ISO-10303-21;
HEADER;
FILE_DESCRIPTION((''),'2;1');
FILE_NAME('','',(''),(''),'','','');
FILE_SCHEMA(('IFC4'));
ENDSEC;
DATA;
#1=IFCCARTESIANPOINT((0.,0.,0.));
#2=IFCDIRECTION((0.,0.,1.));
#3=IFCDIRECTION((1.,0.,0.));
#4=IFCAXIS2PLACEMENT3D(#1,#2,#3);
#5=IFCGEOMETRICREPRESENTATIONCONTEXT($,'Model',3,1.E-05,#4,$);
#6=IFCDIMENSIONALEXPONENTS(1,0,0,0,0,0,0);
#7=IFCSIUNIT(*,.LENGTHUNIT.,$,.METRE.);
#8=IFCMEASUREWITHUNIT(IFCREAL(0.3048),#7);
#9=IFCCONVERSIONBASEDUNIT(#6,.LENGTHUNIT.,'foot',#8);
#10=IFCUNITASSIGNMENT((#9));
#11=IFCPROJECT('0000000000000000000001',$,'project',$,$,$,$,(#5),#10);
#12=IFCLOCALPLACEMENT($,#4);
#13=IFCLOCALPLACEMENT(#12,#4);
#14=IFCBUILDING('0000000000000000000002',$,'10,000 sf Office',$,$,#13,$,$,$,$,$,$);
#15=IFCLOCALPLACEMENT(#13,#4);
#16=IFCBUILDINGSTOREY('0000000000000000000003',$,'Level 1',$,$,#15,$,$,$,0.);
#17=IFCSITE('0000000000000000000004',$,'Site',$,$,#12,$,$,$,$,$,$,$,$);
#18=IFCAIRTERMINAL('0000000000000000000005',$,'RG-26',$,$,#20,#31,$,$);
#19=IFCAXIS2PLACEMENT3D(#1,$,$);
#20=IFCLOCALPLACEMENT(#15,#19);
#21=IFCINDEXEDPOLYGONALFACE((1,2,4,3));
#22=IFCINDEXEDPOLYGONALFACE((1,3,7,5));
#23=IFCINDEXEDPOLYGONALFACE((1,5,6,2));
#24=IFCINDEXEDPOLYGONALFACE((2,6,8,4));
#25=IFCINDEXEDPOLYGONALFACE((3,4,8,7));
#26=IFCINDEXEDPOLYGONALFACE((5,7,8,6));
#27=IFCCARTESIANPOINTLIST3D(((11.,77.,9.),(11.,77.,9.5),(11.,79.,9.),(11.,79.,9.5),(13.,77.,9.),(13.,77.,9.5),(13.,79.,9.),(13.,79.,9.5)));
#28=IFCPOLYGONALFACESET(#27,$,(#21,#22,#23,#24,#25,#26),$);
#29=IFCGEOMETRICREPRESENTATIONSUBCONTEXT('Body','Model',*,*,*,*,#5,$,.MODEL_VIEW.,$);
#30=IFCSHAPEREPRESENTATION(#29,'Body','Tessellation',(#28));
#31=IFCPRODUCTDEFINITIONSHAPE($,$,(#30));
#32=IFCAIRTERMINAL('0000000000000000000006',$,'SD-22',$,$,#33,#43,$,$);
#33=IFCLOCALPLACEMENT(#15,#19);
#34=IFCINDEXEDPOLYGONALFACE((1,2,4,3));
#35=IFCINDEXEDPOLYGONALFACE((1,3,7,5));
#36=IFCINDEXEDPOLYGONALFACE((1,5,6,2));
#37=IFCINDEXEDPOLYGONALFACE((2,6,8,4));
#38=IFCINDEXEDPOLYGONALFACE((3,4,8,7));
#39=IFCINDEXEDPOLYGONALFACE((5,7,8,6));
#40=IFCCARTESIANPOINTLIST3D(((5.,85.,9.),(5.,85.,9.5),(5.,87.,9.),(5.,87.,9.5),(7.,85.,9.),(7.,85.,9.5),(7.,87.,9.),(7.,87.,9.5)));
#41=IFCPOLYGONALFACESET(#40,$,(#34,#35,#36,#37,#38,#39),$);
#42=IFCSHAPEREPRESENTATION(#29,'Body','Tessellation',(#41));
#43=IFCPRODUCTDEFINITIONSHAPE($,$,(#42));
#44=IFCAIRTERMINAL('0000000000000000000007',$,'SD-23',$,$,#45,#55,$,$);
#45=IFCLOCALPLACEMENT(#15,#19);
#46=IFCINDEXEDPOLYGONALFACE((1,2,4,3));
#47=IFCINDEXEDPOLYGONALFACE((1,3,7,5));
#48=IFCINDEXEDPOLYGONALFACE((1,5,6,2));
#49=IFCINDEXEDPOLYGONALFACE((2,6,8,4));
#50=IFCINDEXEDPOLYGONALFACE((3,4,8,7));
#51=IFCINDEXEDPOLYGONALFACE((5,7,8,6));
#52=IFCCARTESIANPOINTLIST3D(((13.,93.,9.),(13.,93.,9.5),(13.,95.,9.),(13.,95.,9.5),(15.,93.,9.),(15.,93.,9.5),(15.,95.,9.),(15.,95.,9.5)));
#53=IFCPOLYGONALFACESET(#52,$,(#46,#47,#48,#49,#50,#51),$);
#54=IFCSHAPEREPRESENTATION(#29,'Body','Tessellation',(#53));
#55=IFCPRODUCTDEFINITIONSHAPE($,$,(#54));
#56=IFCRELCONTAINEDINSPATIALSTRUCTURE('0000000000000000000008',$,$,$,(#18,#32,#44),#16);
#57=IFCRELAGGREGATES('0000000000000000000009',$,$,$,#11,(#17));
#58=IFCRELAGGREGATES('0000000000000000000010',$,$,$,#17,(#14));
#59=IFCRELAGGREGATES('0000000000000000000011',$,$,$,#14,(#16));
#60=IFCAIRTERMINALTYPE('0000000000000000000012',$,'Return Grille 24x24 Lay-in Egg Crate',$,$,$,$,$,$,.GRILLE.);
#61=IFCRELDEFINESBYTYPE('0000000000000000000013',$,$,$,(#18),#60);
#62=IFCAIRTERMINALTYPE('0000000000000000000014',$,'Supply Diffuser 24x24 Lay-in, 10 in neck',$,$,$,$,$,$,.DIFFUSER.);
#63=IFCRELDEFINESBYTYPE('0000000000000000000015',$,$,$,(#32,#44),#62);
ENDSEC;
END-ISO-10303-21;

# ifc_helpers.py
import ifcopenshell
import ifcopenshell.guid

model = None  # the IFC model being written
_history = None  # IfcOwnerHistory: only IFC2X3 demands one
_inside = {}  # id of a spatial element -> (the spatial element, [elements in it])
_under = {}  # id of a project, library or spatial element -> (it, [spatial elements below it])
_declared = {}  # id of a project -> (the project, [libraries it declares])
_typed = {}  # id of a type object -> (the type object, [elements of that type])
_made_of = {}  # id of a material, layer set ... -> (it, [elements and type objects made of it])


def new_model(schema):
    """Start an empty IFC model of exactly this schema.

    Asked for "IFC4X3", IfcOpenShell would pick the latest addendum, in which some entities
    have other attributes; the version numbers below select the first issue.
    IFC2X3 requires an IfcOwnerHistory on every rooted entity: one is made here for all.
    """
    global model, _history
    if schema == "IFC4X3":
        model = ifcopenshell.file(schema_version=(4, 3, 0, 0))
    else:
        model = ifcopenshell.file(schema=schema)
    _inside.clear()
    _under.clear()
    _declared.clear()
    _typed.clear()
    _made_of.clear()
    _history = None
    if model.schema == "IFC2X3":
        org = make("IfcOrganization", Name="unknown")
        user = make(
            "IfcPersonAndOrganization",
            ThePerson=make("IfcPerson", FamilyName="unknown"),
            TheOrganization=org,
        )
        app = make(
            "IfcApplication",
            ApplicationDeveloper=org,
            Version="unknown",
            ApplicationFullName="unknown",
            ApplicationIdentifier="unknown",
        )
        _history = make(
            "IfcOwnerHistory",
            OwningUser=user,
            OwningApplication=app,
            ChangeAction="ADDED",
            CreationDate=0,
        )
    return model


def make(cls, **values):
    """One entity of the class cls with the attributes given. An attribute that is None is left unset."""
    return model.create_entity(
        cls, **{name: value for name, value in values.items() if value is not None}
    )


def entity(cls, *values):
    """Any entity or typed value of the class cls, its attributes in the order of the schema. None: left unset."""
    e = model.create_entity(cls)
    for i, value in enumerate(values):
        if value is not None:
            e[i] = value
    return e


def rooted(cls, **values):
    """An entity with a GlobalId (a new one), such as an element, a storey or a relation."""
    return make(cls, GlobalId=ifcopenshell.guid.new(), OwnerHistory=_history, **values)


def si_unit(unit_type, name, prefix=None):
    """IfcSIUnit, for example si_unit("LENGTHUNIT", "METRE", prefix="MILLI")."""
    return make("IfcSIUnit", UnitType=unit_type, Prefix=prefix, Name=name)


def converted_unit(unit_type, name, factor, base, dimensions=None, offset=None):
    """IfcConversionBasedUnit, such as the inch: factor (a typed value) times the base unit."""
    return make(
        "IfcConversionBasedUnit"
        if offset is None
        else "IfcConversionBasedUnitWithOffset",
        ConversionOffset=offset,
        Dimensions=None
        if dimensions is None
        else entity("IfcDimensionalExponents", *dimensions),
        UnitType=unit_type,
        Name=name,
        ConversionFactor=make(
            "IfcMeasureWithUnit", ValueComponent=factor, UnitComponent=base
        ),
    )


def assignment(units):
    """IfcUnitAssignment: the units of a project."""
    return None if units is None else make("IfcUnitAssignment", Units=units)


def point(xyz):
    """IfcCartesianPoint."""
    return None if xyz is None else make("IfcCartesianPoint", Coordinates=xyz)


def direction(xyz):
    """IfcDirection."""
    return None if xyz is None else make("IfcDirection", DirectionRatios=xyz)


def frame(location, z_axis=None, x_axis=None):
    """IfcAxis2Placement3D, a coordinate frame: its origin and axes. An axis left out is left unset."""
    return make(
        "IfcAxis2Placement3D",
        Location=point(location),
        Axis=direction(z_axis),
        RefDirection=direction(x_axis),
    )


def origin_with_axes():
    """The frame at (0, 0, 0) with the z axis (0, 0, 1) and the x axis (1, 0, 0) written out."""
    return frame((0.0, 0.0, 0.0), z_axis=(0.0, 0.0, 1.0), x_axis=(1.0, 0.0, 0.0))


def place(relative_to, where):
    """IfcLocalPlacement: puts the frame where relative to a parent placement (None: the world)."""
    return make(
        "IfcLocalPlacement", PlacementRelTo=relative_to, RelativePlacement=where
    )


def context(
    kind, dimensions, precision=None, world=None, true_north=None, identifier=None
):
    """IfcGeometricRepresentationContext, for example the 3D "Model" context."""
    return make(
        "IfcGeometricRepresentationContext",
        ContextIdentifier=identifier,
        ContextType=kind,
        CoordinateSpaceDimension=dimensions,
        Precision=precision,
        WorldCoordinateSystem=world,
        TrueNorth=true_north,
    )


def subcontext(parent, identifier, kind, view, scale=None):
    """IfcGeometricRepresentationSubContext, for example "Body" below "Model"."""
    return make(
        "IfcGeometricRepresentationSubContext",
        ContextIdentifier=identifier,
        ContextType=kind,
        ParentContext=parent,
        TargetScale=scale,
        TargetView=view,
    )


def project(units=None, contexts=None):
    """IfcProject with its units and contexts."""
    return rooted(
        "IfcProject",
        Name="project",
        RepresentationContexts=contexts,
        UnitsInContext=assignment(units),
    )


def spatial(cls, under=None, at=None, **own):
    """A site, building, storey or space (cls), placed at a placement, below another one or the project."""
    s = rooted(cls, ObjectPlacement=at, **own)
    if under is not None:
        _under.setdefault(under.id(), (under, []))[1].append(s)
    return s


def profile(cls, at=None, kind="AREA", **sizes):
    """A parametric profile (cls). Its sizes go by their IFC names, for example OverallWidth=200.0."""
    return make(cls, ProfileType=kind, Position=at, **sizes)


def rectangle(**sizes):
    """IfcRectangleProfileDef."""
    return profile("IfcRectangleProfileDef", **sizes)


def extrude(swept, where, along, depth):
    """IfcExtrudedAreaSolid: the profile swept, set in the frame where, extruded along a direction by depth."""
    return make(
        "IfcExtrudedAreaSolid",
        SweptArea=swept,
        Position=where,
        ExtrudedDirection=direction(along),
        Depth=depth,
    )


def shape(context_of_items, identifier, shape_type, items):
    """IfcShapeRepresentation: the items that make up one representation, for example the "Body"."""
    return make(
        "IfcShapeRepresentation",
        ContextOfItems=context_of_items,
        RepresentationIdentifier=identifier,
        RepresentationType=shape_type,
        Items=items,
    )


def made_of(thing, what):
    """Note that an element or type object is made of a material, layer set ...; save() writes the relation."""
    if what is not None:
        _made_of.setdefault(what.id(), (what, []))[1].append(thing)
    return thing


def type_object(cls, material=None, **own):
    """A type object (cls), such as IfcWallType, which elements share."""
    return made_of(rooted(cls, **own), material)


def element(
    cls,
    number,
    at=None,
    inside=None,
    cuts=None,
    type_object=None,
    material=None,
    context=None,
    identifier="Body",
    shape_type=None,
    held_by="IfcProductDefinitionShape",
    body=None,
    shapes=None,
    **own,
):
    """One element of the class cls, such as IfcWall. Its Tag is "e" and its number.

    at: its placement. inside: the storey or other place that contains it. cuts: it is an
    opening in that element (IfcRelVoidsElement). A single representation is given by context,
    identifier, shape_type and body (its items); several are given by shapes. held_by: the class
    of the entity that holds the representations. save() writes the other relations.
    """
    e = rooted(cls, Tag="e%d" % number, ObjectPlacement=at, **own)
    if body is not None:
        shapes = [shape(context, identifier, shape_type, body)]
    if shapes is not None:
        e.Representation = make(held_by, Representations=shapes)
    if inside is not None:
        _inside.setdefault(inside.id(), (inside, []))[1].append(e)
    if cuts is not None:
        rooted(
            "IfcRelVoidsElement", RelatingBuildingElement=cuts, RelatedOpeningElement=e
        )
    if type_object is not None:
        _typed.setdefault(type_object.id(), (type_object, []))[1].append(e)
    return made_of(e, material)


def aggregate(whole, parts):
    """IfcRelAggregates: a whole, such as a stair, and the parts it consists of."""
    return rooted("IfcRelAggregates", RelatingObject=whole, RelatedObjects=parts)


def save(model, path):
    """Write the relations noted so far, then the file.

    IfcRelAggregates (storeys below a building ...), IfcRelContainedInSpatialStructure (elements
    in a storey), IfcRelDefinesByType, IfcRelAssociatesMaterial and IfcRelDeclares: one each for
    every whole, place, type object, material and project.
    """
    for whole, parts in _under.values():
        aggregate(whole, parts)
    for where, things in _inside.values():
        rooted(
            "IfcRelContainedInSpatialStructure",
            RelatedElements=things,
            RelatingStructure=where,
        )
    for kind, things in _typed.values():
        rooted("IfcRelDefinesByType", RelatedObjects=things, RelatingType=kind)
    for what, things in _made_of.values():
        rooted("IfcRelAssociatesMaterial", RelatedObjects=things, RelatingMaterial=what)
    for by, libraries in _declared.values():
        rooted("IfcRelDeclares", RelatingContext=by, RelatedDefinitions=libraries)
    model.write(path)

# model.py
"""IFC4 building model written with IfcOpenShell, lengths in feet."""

from ifc_helpers import new_model, entity, si_unit, converted_unit, frame, origin_with_axes, place, context, subcontext, project, spatial, rectangle, extrude, type_object, element, save


model = new_model("IFC4")

# Units and contexts
model_context = context("Model", 3, precision=1e-05, world=origin_with_axes())
body_context = subcontext(model_context, "Body", "Model", "MODEL_VIEW")
ifc_project = project(units=[converted_unit("LENGTHUNIT", "foot", entity("IfcReal", 0.3048), si_unit("LENGTHUNIT", "METRE"), dimensions=[1, 0, 0, 0, 0, 0, 0])], contexts=[model_context])

# Site, building, storey
site_placement = place(None, origin_with_axes())
site = spatial("IfcSite", under=ifc_project, at=site_placement, Name="Site")
building_placement = place(site_placement, origin_with_axes())
building = spatial("IfcBuilding", under=site, at=building_placement, Name="10,000 sf Office")
storey_placement = place(building_placement, origin_with_axes())
storey = spatial("IfcBuildingStorey", under=building, at=storey_placement, Name="Level 1", Elevation=0.0)

# Air terminals
air_terminal_type_1 = type_object("IfcAirTerminalType", Name="Return Grille 24x24 Lay-in Egg Crate", PredefinedType="GRILLE")
for number, where, z_axis, x_axis, name in (
    (1, (12.0, 78.0, 9.0), (0.0, 0.0, 1.0), (1.0, 0.0, 0.0), "RG-26"),
):
    element("IfcAirTerminal", number, at=place(storey_placement, frame(where, z_axis=z_axis, x_axis=x_axis)), inside=storey, type_object=air_terminal_type_1, Name=name, context=body_context, shape_type="SweptSolid", body=[
        extrude(rectangle(XDim=2.0, YDim=2.0), None, (0.0, 0.0, 1.0), 0.5),
    ])
air_terminal_type_2 = type_object("IfcAirTerminalType", Name="Supply Diffuser 24x24 Lay-in, 10 in neck", PredefinedType="DIFFUSER")
for number, where, z_axis, x_axis, name in (
    (2, (6.0, 86.0, 9.0), (0.0, 0.0, 1.0), (1.0, 0.0, 0.0), "SD-22"),
    (3, (14.0, 94.0, 9.0), (0.0, 0.0, 1.0), (1.0, 0.0, 0.0), "SD-23"),
):
    element("IfcAirTerminal", number, at=place(storey_placement, frame(where, z_axis=z_axis, x_axis=x_axis)), inside=storey, type_object=air_terminal_type_2, Name=name, context=body_context, shape_type="SweptSolid", body=[
        extrude(rectangle(XDim=2.0, YDim=2.0), None, (0.0, 0.0, 1.0), 0.5),
    ])

save(model, "model.ifc")
